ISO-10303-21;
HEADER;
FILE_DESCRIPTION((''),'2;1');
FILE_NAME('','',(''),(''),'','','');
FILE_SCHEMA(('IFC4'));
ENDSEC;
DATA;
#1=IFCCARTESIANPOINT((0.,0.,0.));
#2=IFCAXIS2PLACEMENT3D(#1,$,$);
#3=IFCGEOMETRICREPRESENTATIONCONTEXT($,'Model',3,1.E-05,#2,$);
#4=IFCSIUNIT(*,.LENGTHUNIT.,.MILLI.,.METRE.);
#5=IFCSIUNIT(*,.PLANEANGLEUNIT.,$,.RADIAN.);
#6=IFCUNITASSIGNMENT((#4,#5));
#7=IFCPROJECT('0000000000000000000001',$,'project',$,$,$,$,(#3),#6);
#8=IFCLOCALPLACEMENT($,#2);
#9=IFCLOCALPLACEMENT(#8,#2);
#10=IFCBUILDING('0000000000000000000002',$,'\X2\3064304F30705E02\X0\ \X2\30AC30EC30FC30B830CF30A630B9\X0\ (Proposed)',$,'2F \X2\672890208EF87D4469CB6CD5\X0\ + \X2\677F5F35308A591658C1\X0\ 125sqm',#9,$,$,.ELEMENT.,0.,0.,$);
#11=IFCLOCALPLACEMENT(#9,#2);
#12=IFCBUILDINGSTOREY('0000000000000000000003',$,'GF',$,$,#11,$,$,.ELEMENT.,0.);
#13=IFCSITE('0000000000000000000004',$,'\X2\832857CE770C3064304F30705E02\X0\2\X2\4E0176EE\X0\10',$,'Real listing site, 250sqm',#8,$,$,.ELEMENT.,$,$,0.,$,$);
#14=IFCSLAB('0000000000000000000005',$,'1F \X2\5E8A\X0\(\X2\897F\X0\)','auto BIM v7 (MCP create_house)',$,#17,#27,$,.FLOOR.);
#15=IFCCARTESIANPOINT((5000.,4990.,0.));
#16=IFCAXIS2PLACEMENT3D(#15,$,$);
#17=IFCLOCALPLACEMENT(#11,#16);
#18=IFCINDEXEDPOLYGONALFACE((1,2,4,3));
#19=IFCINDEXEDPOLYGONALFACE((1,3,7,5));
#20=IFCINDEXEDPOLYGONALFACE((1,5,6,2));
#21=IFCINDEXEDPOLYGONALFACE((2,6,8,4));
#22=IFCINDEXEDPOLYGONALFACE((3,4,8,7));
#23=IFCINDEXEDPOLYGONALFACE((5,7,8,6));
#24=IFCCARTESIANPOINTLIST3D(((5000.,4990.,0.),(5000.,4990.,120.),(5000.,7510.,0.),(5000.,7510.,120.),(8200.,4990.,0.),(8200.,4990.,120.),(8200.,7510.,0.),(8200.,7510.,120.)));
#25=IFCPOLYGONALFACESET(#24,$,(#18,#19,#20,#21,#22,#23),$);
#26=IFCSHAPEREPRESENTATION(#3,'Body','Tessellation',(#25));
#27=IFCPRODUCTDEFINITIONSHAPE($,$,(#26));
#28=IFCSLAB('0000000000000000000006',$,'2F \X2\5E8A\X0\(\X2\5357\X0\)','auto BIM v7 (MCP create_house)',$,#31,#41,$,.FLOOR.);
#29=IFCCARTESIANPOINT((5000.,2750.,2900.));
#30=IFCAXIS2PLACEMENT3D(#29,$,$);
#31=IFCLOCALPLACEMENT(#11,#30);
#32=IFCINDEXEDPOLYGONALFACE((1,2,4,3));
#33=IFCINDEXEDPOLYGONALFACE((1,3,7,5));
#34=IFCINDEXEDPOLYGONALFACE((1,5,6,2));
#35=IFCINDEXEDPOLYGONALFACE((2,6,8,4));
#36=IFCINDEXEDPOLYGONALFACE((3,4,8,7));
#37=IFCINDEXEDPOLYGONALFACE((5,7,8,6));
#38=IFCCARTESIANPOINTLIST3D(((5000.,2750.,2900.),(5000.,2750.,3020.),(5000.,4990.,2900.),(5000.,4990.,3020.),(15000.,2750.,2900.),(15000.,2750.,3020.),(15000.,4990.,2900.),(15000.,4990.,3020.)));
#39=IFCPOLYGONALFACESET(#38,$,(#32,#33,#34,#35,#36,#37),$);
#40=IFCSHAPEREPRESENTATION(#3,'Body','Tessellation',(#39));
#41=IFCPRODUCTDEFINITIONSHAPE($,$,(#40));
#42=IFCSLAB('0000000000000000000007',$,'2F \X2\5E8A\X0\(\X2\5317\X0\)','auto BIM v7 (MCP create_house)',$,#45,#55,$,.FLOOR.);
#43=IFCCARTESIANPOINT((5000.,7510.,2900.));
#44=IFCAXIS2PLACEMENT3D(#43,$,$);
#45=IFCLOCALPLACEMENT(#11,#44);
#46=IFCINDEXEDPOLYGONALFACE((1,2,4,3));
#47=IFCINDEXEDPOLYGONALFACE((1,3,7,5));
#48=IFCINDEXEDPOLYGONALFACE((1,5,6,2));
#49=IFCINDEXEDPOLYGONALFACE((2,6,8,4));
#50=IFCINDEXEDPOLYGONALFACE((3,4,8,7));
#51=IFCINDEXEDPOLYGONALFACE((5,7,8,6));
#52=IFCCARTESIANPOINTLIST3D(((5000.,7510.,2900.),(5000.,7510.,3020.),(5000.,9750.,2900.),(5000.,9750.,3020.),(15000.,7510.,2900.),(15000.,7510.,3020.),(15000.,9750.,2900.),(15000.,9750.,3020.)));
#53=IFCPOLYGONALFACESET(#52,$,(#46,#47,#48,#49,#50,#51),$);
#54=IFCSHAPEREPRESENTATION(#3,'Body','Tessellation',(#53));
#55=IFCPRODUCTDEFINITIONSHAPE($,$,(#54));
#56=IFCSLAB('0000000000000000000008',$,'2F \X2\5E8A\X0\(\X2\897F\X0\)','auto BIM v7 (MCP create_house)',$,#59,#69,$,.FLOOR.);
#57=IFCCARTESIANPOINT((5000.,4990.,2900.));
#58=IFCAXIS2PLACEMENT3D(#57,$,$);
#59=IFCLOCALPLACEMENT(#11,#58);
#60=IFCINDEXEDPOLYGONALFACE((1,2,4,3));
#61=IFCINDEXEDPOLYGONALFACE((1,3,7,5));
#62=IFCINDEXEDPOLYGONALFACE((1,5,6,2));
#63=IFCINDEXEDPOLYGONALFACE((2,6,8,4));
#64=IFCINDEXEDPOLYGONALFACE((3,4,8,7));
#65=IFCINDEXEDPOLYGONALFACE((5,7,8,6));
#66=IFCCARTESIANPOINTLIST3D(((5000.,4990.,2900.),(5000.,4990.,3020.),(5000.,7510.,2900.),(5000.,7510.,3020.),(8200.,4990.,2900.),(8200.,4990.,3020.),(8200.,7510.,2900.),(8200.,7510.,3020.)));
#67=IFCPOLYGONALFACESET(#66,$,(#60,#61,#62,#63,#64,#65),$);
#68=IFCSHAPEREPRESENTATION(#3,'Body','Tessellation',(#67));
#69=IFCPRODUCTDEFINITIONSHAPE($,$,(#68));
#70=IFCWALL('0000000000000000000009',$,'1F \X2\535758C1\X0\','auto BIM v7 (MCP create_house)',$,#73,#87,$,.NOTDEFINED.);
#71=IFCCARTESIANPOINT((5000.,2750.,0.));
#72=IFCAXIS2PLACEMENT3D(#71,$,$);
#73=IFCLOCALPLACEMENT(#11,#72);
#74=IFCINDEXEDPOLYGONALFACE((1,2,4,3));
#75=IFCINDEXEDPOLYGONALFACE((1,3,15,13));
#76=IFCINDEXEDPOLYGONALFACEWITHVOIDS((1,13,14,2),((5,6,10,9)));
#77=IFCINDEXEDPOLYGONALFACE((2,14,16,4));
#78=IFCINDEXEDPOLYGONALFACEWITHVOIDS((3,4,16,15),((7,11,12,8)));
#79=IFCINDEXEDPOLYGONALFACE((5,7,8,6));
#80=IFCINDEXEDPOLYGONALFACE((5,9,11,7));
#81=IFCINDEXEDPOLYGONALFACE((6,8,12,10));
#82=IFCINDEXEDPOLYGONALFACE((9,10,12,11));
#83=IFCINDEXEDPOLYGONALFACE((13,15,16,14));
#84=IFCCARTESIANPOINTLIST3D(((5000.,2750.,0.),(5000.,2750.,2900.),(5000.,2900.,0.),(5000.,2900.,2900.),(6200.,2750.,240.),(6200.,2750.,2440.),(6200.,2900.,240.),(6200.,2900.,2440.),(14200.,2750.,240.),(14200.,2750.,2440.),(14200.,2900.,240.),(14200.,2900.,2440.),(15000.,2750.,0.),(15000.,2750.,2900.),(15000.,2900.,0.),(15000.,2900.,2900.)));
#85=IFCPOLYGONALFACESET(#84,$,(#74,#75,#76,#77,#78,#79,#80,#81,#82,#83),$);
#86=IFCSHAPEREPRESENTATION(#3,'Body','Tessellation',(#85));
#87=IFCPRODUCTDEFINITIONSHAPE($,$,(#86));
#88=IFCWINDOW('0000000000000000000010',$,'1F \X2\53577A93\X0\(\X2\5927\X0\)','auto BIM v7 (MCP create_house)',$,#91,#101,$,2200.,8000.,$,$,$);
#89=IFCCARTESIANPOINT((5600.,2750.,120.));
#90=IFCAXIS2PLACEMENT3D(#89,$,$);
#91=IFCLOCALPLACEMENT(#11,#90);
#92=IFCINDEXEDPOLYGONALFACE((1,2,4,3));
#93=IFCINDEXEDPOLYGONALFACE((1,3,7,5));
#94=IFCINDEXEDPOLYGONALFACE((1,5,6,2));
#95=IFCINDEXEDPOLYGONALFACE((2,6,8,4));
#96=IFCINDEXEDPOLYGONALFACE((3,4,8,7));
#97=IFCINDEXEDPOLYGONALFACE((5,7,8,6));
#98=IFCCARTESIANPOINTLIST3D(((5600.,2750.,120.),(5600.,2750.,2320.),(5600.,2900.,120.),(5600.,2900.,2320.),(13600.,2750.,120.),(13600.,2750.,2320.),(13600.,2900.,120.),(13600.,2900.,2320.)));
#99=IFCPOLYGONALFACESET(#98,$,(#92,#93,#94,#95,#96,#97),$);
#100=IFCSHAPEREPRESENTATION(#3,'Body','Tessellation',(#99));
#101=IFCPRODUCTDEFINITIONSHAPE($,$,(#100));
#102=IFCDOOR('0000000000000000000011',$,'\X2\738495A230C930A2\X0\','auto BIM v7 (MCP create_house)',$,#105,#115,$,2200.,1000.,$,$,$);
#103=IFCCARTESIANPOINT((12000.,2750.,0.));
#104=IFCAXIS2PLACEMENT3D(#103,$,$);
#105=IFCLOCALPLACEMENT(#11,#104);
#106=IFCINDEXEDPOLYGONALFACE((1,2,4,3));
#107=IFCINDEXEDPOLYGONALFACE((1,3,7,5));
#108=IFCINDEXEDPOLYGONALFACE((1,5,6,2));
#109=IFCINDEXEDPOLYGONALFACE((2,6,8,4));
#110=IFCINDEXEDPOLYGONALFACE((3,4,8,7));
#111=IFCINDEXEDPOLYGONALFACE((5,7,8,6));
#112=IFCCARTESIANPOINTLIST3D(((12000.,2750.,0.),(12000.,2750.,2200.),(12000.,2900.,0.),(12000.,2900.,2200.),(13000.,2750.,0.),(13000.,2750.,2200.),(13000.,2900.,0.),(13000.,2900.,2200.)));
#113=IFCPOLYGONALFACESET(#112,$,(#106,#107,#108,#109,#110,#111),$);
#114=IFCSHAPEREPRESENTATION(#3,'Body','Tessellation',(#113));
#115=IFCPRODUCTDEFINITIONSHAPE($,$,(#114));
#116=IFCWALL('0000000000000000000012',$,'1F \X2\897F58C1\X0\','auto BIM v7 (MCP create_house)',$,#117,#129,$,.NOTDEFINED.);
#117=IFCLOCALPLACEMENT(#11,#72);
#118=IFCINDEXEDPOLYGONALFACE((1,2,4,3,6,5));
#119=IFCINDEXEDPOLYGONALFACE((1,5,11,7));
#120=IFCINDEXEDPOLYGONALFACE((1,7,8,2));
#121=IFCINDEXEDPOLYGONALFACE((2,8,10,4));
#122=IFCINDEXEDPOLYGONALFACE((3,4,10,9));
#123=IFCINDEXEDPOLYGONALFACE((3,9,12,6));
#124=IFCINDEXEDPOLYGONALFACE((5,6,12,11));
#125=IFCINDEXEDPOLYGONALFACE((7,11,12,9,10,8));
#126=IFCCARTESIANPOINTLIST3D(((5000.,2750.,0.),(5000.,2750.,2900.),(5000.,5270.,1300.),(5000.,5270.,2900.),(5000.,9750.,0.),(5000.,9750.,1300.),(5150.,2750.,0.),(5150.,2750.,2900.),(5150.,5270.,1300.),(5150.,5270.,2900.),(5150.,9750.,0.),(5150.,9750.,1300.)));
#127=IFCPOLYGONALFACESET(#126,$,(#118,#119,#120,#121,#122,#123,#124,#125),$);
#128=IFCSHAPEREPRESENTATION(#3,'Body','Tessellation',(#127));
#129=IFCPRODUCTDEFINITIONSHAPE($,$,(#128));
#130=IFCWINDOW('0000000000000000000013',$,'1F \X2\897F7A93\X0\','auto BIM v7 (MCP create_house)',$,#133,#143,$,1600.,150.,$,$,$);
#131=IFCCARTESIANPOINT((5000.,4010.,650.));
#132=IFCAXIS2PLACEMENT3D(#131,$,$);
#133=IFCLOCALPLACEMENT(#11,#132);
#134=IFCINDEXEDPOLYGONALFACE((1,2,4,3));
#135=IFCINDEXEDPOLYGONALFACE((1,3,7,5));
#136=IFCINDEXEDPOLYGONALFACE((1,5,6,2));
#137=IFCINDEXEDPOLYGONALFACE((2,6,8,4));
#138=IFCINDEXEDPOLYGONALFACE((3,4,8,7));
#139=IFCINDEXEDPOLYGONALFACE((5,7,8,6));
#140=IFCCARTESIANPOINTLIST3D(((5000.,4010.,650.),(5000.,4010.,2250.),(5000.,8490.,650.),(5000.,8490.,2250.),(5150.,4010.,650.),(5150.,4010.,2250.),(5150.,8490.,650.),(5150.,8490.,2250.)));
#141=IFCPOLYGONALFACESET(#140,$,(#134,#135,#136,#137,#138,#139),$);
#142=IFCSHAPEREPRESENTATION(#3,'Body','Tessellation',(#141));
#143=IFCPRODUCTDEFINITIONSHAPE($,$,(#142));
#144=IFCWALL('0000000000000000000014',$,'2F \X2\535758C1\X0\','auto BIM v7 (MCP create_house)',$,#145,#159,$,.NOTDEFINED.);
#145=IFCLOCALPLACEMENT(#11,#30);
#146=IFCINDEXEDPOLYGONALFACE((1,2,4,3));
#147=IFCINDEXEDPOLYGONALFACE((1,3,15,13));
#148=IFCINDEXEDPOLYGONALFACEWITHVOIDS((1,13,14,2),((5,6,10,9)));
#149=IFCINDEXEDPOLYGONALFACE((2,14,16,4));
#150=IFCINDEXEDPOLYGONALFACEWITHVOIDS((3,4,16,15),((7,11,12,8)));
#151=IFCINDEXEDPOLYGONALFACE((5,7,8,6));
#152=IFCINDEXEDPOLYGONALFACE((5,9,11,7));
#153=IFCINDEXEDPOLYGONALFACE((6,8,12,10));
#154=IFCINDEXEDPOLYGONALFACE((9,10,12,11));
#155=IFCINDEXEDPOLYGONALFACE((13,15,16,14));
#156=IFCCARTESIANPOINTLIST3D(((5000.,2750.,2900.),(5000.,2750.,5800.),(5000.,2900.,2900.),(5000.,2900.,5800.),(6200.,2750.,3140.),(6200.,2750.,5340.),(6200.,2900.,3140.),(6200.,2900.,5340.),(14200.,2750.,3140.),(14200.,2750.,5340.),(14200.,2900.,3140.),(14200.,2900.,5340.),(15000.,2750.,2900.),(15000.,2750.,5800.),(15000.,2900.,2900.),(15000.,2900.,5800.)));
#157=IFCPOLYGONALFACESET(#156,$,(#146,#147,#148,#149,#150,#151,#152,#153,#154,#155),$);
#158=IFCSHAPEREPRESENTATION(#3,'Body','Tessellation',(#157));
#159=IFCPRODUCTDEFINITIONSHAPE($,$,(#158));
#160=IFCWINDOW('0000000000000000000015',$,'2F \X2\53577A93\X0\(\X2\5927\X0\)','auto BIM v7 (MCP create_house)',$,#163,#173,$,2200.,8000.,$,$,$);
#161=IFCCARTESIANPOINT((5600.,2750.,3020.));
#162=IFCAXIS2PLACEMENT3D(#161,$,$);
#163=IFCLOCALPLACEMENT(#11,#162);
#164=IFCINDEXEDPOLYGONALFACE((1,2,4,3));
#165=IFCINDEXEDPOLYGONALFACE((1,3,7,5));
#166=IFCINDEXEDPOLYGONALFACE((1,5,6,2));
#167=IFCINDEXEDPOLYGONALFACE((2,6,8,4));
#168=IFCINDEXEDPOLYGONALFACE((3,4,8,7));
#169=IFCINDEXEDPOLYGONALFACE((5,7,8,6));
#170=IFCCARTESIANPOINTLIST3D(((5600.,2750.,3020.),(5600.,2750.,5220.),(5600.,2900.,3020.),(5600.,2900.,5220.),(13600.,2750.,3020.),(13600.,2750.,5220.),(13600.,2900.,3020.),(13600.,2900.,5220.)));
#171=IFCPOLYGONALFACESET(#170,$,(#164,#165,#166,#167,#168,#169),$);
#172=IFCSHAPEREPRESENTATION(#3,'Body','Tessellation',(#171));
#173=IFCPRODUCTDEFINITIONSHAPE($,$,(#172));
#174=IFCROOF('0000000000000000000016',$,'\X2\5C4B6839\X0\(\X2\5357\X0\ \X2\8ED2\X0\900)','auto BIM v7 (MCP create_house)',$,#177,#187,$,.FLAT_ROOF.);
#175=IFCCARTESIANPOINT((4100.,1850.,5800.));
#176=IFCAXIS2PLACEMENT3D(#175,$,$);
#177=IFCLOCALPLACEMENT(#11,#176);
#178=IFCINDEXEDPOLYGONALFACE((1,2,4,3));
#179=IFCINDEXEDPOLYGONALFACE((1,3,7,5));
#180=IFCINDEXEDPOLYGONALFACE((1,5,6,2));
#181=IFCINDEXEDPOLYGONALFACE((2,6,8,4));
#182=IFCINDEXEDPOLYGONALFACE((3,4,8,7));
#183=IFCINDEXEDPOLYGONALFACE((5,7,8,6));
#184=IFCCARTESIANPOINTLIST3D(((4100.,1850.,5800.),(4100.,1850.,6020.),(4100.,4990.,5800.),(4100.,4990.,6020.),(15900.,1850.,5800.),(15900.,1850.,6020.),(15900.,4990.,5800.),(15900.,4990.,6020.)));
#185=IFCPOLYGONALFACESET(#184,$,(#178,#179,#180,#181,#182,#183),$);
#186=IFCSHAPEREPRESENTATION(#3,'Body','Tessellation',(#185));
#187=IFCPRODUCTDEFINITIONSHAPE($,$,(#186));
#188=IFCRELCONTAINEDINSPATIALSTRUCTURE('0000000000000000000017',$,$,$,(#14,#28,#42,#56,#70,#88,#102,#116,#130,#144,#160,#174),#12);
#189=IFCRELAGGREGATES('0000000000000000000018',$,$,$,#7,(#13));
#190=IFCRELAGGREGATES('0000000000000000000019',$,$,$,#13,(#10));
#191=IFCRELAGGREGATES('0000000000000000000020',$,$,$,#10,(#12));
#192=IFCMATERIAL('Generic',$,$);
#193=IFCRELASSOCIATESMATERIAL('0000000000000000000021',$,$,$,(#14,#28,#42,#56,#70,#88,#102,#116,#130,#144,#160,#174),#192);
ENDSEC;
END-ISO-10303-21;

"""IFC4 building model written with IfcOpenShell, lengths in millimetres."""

from ifc_helpers import new_model, si_unit, frame, frame_2d, origin, place, context, project, spatial, rectangle, extrude, material, element, fill, save


model = new_model("IFC4")

# Units and contexts
model_context = context("Model", 3, precision=1e-05, world=origin())
ifc_project = project(units=[si_unit("LENGTHUNIT", "METRE", prefix="MILLI"), si_unit("PLANEANGLEUNIT", "RADIAN")], contexts=[model_context])

# Site, building, storey
site_placement = place(None, origin())
site = spatial("IfcSite", under=ifc_project, at=site_placement, Name="茨城県つくば市2丁目10", ObjectType="Real listing site, 250sqm", CompositionType="ELEMENT", RefElevation=0.0)
building_placement = place(site_placement, origin())
building = spatial("IfcBuilding", under=site, at=building_placement, Name="つくば市 ガレージハウス (Proposed)", ObjectType="2F 木造軸組構法 + 板張り外壁 125sqm", CompositionType="ELEMENT", ElevationOfRefHeight=0.0, ElevationOfTerrain=0.0)
storey_placement = place(building_placement, origin())
storey = spatial("IfcBuildingStorey", under=building, at=storey_placement, Name="GF", CompositionType="ELEMENT", Elevation=0.0)

# Slabs
ifc_material = material(Name="Generic")
slab_1_placement = place(storey_placement, frame((5000.0, 4990.0, 0.0)))
element("IfcSlab", 1, at=slab_1_placement, inside=storey, material=ifc_material, Name="1F 床(西)", Description="auto BIM v7 (MCP create_house)", PredefinedType="FLOOR", context=model_context, shape_type="SweptSolid", body=[
    extrude(rectangle(XDim=3200.0, YDim=2520.0, at=frame_2d((1600.0, 1260.0))), frame((5000.0, 4990.0, 0.0)), (0.0, 0.0, 1.0), 120.0),
])
slab_2_placement = place(storey_placement, frame((5000.0, 2750.0, 2900.0)))
element("IfcSlab", 2, at=slab_2_placement, inside=storey, material=ifc_material, Name="2F 床(南)", Description="auto BIM v7 (MCP create_house)", PredefinedType="FLOOR", context=model_context, shape_type="SweptSolid", body=[
    extrude(rectangle(XDim=10000.0, YDim=2240.0, at=frame_2d((5000.0, 1120.0))), frame((5000.0, 2750.0, 2900.0)), (0.0, 0.0, 1.0), 120.0),
])
slab_3_placement = place(storey_placement, frame((5000.0, 7510.0, 2900.0)))
element("IfcSlab", 3, at=slab_3_placement, inside=storey, material=ifc_material, Name="2F 床(北)", Description="auto BIM v7 (MCP create_house)", PredefinedType="FLOOR", context=model_context, shape_type="SweptSolid", body=[
    extrude(rectangle(XDim=10000.0, YDim=2240.0, at=frame_2d((5000.0, 1120.0))), frame((5000.0, 7510.0, 2900.0)), (0.0, 0.0, 1.0), 120.0),
])
slab_4_placement = place(storey_placement, frame((5000.0, 4990.0, 2900.0)))
element("IfcSlab", 4, at=slab_4_placement, inside=storey, material=ifc_material, Name="2F 床(西)", Description="auto BIM v7 (MCP create_house)", PredefinedType="FLOOR", context=model_context, shape_type="SweptSolid", body=[
    extrude(rectangle(XDim=3200.0, YDim=2520.0, at=frame_2d((1600.0, 1260.0))), frame((5000.0, 4990.0, 2900.0)), (0.0, 0.0, 1.0), 120.0),
])

# Wall, openings, window, door
wall_1_placement = place(storey_placement, frame((5000.0, 2750.0, 0.0)))
wall_1 = element("IfcWall", 5, at=wall_1_placement, inside=storey, material=ifc_material, Name="1F 南壁", Description="auto BIM v7 (MCP create_house)", PredefinedType="NOTDEFINED", context=model_context, shape_type="SweptSolid", body=[
    extrude(rectangle(XDim=10000.0, YDim=150.0, at=frame_2d((5000.0, 75.0))), frame((5000.0, 2750.0, 0.0)), (0.0, 0.0, 1.0), 2900.0),
])
opening_1_placement = place(storey_placement, frame((5600.0, 2750.0, 120.0)))
opening_1 = element("IfcOpeningElement", 6, at=opening_1_placement, cuts=wall_1, PredefinedType="NOTDEFINED", context=model_context, shape_type="SweptSolid", body=[
    extrude(rectangle(XDim=8000.0, YDim=150.0, at=frame_2d((4000.0, 75.0))), frame((5600.0, 2750.0, 120.0)), (0.0, 0.0, 1.0), 2200.0),
])
opening_2_placement = place(storey_placement, frame((12000.0, 2750.0, 0.0)))
opening_2 = element("IfcOpeningElement", 7, at=opening_2_placement, cuts=wall_1, PredefinedType="NOTDEFINED", context=model_context, shape_type="SweptSolid", body=[
    extrude(rectangle(XDim=1000.0, YDim=150.0, at=frame_2d((500.0, 75.0))), frame((12000.0, 2750.0, 0.0)), (0.0, 0.0, 1.0), 2200.0),
])
window_1_placement = place(storey_placement, frame((5600.0, 2750.0, 120.0)))
window_1 = element("IfcWindow", 8, at=window_1_placement, inside=storey, material=ifc_material, Name="1F 南窓(大)", Description="auto BIM v7 (MCP create_house)", OverallHeight=2200.0, OverallWidth=8000.0, context=model_context, shape_type="SweptSolid", body=[
    extrude(rectangle(XDim=8000.0, YDim=150.0, at=frame_2d((4000.0, 75.0))), frame((5600.0, 2750.0, 120.0)), (0.0, 0.0, 1.0), 2200.0),
])
fill(opening_1, window_1)
door_placement = place(storey_placement, frame((12000.0, 2750.0, 0.0)))
door = element("IfcDoor", 9, at=door_placement, inside=storey, material=ifc_material, Name="玄関ドア", Description="auto BIM v7 (MCP create_house)", OverallHeight=2200.0, OverallWidth=1000.0, context=model_context, shape_type="SweptSolid", body=[
    extrude(rectangle(XDim=1000.0, YDim=150.0, at=frame_2d((500.0, 75.0))), frame((12000.0, 2750.0, 0.0)), (0.0, 0.0, 1.0), 2200.0),
])
fill(opening_2, door)

# Walls, openings, windows
wall_2_placement = place(storey_placement, frame((5000.0, 2750.0, 0.0)))
wall_2 = element("IfcWall", 10, at=wall_2_placement, inside=storey, material=ifc_material, Name="1F 西壁", Description="auto BIM v7 (MCP create_house)", PredefinedType="NOTDEFINED", context=model_context, shape_type="SweptSolid", body=[
    extrude(rectangle(XDim=150.0, YDim=7000.0, at=frame_2d((75.0, 3500.0))), frame((5000.0, 2750.0, 0.0)), (0.0, 0.0, 1.0), 2900.0),
])
opening_3_placement = place(storey_placement, frame((5000.0, 4010.0, 650.0)))
opening_3 = element("IfcOpeningElement", 11, at=opening_3_placement, cuts=wall_2, PredefinedType="NOTDEFINED", context=model_context, shape_type="SweptSolid", body=[
    extrude(rectangle(XDim=150.0, YDim=4480.0, at=frame_2d((75.0, 2240.0))), frame((5000.0, 4010.0, 650.0)), (0.0, 0.0, 1.0), 1600.0),
])
window_2_placement = place(storey_placement, frame((5000.0, 4010.0, 650.0)))
window_2 = element("IfcWindow", 12, at=window_2_placement, inside=storey, material=ifc_material, Name="1F 西窓", Description="auto BIM v7 (MCP create_house)", OverallHeight=1600.0, OverallWidth=150.0, context=model_context, shape_type="SweptSolid", body=[
    extrude(rectangle(XDim=150.0, YDim=4480.0, at=frame_2d((75.0, 2240.0))), frame((5000.0, 4010.0, 650.0)), (0.0, 0.0, 1.0), 1600.0),
])
fill(opening_3, window_2)
wall_3_placement = place(storey_placement, frame((5000.0, 2750.0, 2900.0)))
wall_3 = element("IfcWall", 13, at=wall_3_placement, inside=storey, material=ifc_material, Name="2F 南壁", Description="auto BIM v7 (MCP create_house)", PredefinedType="NOTDEFINED", context=model_context, shape_type="SweptSolid", body=[
    extrude(rectangle(XDim=10000.0, YDim=150.0, at=frame_2d((5000.0, 75.0))), frame((5000.0, 2750.0, 2900.0)), (0.0, 0.0, 1.0), 2900.0),
])
opening_4_placement = place(storey_placement, frame((5600.0, 2750.0, 3020.0)))
opening_4 = element("IfcOpeningElement", 14, at=opening_4_placement, cuts=wall_3, PredefinedType="NOTDEFINED", context=model_context, shape_type="SweptSolid", body=[
    extrude(rectangle(XDim=8000.0, YDim=150.0, at=frame_2d((4000.0, 75.0))), frame((5600.0, 2750.0, 3020.0)), (0.0, 0.0, 1.0), 2200.0),
])
window_3_placement = place(storey_placement, frame((5600.0, 2750.0, 3020.0)))
window_3 = element("IfcWindow", 15, at=window_3_placement, inside=storey, material=ifc_material, Name="2F 南窓(大)", Description="auto BIM v7 (MCP create_house)", OverallHeight=2200.0, OverallWidth=8000.0, context=model_context, shape_type="SweptSolid", body=[
    extrude(rectangle(XDim=8000.0, YDim=150.0, at=frame_2d((4000.0, 75.0))), frame((5600.0, 2750.0, 3020.0)), (0.0, 0.0, 1.0), 2200.0),
])
fill(opening_4, window_3)

# Roof
roof_1_placement = place(storey_placement, frame((4100.0, 1850.0, 5800.0)))
element("IfcRoof", 16, at=roof_1_placement, inside=storey, material=ifc_material, Name="屋根(南 軒900)", Description="auto BIM v7 (MCP create_house)", PredefinedType="FLAT_ROOF", context=model_context, shape_type="SweptSolid", body=[
    extrude(rectangle(XDim=11800.0, YDim=3140.0, at=frame_2d((5900.0, 1570.0))), frame((4100.0, 1850.0, 5800.0)), (0.0, 0.0, 1.0), 220.0),
])

save(model, "model.ifc")
